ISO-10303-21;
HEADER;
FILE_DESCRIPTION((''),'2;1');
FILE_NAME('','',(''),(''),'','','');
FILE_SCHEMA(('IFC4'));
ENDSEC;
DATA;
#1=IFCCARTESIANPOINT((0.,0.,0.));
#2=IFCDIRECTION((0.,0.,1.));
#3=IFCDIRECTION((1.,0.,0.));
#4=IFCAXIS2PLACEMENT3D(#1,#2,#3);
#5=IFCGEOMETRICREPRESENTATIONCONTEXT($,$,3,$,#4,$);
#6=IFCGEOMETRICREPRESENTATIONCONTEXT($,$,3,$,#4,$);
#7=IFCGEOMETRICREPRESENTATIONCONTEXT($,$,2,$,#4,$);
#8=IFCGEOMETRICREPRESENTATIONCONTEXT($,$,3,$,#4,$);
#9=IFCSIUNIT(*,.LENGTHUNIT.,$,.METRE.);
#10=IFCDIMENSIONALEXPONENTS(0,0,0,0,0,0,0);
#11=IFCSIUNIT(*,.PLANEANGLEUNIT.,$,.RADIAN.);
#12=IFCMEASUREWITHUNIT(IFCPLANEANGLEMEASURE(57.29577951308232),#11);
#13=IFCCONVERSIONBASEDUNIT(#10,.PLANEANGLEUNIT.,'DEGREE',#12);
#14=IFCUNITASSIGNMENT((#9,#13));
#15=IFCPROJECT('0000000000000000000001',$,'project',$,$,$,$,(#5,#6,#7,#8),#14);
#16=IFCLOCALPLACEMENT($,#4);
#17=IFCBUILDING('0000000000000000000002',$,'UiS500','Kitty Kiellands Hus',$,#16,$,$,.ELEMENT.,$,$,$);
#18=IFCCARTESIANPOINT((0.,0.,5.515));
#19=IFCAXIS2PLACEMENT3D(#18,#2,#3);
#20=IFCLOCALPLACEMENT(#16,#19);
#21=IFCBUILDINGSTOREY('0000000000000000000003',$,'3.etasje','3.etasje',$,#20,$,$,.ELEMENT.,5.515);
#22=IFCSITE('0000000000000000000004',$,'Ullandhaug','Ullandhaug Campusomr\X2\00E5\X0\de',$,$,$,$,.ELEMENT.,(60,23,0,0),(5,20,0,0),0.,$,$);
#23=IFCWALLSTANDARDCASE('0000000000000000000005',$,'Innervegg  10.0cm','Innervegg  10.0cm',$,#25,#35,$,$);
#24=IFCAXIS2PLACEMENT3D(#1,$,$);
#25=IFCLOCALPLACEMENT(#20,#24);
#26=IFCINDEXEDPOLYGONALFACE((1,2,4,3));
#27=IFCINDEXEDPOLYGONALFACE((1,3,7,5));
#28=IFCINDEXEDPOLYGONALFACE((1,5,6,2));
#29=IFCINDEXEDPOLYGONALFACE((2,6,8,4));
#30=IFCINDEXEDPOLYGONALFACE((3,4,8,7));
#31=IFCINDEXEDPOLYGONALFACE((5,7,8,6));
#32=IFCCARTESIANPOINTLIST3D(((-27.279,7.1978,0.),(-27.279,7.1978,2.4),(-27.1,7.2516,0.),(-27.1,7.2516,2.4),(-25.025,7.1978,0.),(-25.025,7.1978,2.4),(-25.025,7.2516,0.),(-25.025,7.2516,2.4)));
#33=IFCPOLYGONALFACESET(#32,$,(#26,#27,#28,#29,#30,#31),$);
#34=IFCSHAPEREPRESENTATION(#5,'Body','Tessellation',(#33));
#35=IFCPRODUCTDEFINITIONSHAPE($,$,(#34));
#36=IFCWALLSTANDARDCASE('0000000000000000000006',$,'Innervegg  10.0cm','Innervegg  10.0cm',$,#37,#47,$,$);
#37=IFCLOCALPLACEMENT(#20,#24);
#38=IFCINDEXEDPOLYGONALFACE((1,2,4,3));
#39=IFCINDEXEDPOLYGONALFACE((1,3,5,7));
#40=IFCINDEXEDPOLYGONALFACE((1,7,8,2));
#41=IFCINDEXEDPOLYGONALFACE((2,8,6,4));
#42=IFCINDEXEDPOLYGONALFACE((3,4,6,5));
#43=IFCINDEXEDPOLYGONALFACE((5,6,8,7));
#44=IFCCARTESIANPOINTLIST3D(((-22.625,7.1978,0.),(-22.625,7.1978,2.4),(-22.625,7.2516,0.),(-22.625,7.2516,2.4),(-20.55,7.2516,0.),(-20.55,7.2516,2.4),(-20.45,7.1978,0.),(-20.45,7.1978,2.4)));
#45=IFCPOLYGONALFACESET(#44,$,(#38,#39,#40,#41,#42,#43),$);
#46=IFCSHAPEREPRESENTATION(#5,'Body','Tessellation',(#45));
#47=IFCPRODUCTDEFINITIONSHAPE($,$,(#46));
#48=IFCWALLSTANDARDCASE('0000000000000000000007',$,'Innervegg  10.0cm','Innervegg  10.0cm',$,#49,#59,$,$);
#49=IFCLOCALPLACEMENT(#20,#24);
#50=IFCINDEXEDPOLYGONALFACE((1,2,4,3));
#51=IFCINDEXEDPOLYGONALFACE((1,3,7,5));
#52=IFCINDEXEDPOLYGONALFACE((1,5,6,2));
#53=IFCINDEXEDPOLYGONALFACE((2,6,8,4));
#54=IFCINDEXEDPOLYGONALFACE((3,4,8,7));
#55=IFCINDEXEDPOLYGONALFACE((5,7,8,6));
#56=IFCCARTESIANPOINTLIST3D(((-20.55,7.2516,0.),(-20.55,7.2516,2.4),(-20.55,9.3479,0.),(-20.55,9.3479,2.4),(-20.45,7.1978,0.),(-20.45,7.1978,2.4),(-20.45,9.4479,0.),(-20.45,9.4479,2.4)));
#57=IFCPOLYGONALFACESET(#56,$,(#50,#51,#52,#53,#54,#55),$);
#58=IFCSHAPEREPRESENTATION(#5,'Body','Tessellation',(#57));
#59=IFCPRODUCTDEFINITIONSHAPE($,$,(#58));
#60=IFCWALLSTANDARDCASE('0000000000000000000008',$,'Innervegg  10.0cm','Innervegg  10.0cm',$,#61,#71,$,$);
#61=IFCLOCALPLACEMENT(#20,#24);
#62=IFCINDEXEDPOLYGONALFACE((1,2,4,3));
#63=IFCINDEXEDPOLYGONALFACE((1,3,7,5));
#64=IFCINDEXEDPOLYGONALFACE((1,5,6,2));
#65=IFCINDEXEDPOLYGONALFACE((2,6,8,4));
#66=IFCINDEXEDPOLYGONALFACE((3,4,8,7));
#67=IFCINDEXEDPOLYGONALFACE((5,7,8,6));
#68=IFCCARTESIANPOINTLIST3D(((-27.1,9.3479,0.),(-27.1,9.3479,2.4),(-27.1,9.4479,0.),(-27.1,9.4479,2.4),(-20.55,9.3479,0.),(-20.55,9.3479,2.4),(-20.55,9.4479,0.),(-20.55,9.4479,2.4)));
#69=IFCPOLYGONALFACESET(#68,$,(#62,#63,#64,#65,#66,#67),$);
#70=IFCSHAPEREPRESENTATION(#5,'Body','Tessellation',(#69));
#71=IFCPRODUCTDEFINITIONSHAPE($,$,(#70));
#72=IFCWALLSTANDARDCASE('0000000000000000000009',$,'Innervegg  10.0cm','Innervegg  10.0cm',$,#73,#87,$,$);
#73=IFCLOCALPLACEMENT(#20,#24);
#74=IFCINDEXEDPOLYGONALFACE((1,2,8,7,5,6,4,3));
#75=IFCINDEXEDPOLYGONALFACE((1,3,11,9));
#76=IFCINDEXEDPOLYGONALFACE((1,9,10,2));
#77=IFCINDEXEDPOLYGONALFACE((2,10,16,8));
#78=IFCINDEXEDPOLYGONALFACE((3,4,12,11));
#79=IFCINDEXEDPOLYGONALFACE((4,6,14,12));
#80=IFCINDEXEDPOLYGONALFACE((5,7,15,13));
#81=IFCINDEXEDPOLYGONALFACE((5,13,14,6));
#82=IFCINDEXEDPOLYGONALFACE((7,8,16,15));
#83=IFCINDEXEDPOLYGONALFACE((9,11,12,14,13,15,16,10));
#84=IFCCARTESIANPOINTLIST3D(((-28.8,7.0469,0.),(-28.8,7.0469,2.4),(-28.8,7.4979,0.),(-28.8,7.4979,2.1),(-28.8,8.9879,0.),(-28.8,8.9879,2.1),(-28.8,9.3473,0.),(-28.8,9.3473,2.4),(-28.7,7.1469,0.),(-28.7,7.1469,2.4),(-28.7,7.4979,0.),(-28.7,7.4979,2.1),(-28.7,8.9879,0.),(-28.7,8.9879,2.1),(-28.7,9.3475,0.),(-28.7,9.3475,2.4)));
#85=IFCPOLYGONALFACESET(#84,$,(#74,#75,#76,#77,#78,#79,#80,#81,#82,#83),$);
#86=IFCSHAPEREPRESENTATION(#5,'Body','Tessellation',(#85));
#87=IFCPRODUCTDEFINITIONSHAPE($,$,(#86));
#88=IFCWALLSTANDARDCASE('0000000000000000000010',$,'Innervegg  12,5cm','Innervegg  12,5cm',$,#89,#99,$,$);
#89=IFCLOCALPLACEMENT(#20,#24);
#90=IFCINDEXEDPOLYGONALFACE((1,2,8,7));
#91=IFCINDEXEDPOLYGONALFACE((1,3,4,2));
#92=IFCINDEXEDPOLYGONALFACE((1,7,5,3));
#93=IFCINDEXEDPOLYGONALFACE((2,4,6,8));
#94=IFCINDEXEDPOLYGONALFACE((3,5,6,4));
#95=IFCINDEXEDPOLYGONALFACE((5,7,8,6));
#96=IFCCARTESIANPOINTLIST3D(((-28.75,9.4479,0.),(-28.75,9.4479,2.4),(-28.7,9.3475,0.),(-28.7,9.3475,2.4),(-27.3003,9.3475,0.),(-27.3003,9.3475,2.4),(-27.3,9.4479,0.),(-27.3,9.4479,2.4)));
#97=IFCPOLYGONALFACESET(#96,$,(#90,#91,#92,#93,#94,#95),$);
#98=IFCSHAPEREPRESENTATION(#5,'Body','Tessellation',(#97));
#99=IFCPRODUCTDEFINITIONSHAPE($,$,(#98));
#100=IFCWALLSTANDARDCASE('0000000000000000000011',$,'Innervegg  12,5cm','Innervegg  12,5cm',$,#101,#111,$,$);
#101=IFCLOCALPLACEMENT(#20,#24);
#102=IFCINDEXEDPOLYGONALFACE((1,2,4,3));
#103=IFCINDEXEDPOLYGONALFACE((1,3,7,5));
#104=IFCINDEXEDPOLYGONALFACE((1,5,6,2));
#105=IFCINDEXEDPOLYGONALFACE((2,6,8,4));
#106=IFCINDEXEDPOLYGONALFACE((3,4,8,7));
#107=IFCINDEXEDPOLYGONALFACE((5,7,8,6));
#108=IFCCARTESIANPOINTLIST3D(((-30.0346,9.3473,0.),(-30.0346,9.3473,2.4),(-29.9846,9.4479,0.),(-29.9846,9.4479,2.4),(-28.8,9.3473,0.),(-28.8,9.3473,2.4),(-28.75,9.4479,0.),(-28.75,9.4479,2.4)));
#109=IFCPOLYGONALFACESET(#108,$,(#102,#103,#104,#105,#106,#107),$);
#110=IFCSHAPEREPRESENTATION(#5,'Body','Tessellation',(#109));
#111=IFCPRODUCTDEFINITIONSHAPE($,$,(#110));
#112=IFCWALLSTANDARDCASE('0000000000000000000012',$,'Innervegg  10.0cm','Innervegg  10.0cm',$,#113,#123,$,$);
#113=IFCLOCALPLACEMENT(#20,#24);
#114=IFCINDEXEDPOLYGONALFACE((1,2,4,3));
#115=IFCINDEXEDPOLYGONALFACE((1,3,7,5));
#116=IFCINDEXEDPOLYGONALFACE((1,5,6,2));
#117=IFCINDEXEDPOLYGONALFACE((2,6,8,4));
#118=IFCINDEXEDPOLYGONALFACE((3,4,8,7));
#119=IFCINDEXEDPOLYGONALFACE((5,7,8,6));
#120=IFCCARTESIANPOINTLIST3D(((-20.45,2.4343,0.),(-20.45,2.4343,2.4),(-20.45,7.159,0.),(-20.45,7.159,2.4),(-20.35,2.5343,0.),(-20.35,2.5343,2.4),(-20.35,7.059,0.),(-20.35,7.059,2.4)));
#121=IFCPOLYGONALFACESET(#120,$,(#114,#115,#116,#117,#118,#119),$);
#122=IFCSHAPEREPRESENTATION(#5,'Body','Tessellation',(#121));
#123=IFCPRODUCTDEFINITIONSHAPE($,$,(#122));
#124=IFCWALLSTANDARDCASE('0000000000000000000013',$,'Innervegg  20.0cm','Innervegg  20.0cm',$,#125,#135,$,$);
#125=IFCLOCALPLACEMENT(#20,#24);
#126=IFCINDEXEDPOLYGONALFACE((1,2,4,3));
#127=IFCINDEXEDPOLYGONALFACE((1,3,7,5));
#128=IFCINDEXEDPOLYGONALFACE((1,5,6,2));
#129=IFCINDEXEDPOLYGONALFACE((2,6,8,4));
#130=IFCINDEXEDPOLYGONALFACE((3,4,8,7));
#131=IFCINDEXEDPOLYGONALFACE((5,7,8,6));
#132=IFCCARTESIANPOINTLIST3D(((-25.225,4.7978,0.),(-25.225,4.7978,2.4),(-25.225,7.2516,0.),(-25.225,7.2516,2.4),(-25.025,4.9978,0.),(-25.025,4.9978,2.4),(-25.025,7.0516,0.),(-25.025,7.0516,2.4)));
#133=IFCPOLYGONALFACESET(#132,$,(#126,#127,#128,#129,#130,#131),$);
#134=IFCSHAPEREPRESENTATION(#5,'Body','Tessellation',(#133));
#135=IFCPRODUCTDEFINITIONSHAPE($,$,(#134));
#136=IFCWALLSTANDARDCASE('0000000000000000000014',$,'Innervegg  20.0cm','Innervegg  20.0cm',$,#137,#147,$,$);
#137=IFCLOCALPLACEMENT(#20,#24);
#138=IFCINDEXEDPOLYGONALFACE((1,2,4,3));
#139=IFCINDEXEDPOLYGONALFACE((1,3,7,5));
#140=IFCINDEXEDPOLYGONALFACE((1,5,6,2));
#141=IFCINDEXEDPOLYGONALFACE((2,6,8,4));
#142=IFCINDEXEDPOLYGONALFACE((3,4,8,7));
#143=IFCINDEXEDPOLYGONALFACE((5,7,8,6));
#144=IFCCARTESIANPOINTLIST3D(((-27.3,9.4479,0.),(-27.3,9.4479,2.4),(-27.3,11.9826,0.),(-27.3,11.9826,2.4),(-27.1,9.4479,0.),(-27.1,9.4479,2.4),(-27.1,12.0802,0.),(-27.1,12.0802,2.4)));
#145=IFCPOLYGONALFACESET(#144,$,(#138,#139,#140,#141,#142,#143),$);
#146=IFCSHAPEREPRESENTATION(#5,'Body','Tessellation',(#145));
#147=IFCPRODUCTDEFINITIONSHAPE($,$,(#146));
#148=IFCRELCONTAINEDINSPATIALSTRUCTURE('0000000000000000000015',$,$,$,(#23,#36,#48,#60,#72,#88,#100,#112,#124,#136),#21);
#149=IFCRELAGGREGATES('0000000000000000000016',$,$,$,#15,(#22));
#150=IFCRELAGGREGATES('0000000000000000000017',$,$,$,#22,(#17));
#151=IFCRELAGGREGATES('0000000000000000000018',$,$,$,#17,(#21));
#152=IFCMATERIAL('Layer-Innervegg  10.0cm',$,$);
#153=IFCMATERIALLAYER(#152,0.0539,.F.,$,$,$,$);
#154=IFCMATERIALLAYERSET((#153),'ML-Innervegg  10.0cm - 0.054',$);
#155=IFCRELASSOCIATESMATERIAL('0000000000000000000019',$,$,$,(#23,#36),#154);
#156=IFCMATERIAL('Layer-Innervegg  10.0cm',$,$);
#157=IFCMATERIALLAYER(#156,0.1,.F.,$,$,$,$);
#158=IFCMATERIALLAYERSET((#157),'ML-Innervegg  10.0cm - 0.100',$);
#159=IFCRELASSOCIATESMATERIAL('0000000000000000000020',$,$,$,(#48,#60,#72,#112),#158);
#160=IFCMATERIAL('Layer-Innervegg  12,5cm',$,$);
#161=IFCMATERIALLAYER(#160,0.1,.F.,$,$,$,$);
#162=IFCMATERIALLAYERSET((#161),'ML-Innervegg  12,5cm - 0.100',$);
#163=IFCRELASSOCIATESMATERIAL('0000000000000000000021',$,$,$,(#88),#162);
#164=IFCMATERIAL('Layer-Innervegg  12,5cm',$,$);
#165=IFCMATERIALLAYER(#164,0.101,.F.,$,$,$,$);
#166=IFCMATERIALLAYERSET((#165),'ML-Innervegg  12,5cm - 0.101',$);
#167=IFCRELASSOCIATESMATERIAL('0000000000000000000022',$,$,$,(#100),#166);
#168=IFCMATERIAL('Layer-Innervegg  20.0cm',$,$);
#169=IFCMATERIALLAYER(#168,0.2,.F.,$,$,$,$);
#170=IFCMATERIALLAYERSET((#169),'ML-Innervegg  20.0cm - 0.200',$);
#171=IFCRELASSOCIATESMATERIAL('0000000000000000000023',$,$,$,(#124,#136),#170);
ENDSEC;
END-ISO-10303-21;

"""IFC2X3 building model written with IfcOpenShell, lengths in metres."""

from ifc_helpers import new_model, entity, si_unit, converted_unit, frame, origin_with_axes, place, context, project, spatial, polyline, outline, extrude, material, layer, layer_set, layer_usage, element, save


model = new_model("IFC2X3")

# Units and contexts
context_of_model_1 = context(None, 3, world=origin_with_axes())
context_of_model_2 = context(None, 3, world=origin_with_axes())
context_of_model_3 = context(None, 2, world=origin_with_axes())
context_of_model_4 = context(None, 3, world=origin_with_axes())
ifc_project = project(units=[si_unit("LENGTHUNIT", "METRE"), converted_unit("PLANEANGLEUNIT", "DEGREE", entity("IfcPlaneAngleMeasure", 57.29577951308232), si_unit("PLANEANGLEUNIT", "RADIAN"), dimensions=[0, 0, 0, 0, 0, 0, 0])], contexts=[context_of_model_1, context_of_model_2, context_of_model_3, context_of_model_4])

# Site, building, storey
site = spatial("IfcSite", under=ifc_project, Name="Ullandhaug", Description="Ullandhaug Campusområde", CompositionType="ELEMENT", RefLatitude=(60, 23, 0, 0), RefLongitude=(5, 20, 0, 0), RefElevation=0.0)
building_placement = place(None, origin_with_axes())
building = spatial("IfcBuilding", under=site, at=building_placement, Name="UiS500", Description="Kitty Kiellands Hus", CompositionType="ELEMENT")
storey_placement = place(building_placement, frame((0.0, 0.0, 5.515), z_axis=(0.0, 0.0, 1.0), x_axis=(1.0, 0.0, 0.0)))
storey = spatial("IfcBuildingStorey", under=building, at=storey_placement, Name="3.etasje", Description="3.etasje", CompositionType="ELEMENT", Elevation=5.515)

# Shared definitions
ifc_material_1 = material(Name="Layer-Innervegg  10.0cm")
ifc_layer_1 = layer(ifc_material_1, 0.1, ventilated=False)
ifc_layer_set_1 = layer_set([ifc_layer_1], Name="ML-Innervegg  10.0cm - 0.100")
ifc_layer_usage_1 = layer_usage(ifc_layer_set_1, "AXIS2", "POSITIVE", 0.0)
ifc_material_2 = material(Name="Layer-Innervegg  20.0cm")
ifc_layer_2 = layer(ifc_material_2, 0.2, ventilated=False)
ifc_layer_set_2 = layer_set([ifc_layer_2], Name="ML-Innervegg  20.0cm - 0.200")
ifc_layer_usage_2 = layer_usage(ifc_layer_set_2, "AXIS2", "POSITIVE", 0.0)

# Walls
ifc_material_3 = material(Name="Layer-Innervegg  10.0cm")
ifc_layer_3 = layer(ifc_material_3, 0.0539, ventilated=False)
ifc_layer_set_3 = layer_set([ifc_layer_3], Name="ML-Innervegg  10.0cm - 0.054")
ifc_layer_usage_3 = layer_usage(ifc_layer_set_3, "AXIS2", "POSITIVE", 0.0)
wall_1_placement = place(storey_placement, frame((-27.279, 7.1978, 0.0), z_axis=(0.0, 0.0, 1.0), x_axis=(1.0, 0.0, 0.0)))
element("IfcWallStandardCase", 1, at=wall_1_placement, inside=storey, material=ifc_layer_usage_3, Name="Innervegg  10.0cm", Description="Innervegg  10.0cm", context=context_of_model_1, shape_type="SweptSolid", body=[
    extrude(outline(polyline([(0.0, 0.0), (2.254, 0.0), (2.254, 0.0539), (0.179, 0.0539), (0.0, 0.0)])), origin_with_axes(), (0.0, 0.0, 1.0), 2.4),
])
wall_2_placement = place(storey_placement, frame((-22.625, 7.1978, 0.0), z_axis=(0.0, 0.0, 1.0), x_axis=(1.0, 0.0, 0.0)))
element("IfcWallStandardCase", 2, at=wall_2_placement, inside=storey, material=ifc_layer_usage_3, Name="Innervegg  10.0cm", Description="Innervegg  10.0cm", context=context_of_model_1, shape_type="SweptSolid", body=[
    extrude(outline(polyline([(0.0, 0.0), (2.175, 0.0), (2.075, 0.0539), (0.0, 0.0539), (0.0, 0.0)])), origin_with_axes(), (0.0, 0.0, 1.0), 2.4),
])
wall_3_placement = place(storey_placement, frame((-20.45, 7.1978, 0.0), z_axis=(0.0, 0.0, 1.0), x_axis=(0.0, 1.0, 0.0)))
element("IfcWallStandardCase", 3, at=wall_3_placement, inside=storey, material=ifc_layer_usage_1, Name="Innervegg  10.0cm", Description="Innervegg  10.0cm", context=context_of_model_1, shape_type="SweptSolid", body=[
    extrude(outline(polyline([(0.0, 0.0), (2.2502, 0.0), (2.1502, 0.1), (0.0539, 0.1), (0.0, 0.0)])), frame((0.0, 0.0, 0.0), z_axis=(0.0, 0.0, 1.0), x_axis=(1.0, 0.0, 0.0)), (0.0, 0.0, 1.0), 2.4),
])
wall_4_placement = place(storey_placement, frame((-20.55, 9.4479, 0.0), z_axis=(0.0, 0.0, 1.0), x_axis=(-1.0, 0.000003, 0.0)))
element("IfcWallStandardCase", 4, at=wall_4_placement, inside=storey, material=ifc_layer_usage_1, Name="Innervegg  10.0cm", Description="Innervegg  10.0cm", context=context_of_model_1, shape_type="SweptSolid", body=[
    extrude(outline(polyline([(0.0, 0.0), (6.55, 0.0), (6.55, 0.1), (0.0, 0.1), (0.0, 0.0)])), frame((0.0, 0.0, 0.0), z_axis=(0.0, 0.0, 1.0), x_axis=(1.0, 0.0, 0.0)), (0.0, 0.0, 1.0), 2.4),
])

# Wall, opening
wall_5_placement = place(storey_placement, frame((-28.8, 9.3473, 0.0), z_axis=(0.0, 0.0, 1.0), x_axis=(0.0, -1.0, 0.0)))
wall_5 = element("IfcWallStandardCase", 5, at=wall_5_placement, inside=storey, material=ifc_layer_usage_1, Name="Innervegg  10.0cm", Description="Innervegg  10.0cm", context=context_of_model_1, shape_type="SweptSolid", body=[
    extrude(outline(polyline([(0.0, 0.0), (2.3004, 0.0), (2.2004, 0.1), (-0.0002, 0.1), (0.0, 0.0)])), frame((0.0, 0.0, 0.0), z_axis=(0.0, 0.0, 1.0), x_axis=(1.0, 0.0, 0.0)), (0.0, 0.0, 1.0), 2.4),
])
opening_1_placement = place(wall_5_placement, frame((0.3594, 0.1, 0.0), z_axis=(0.0, 0.0, 1.0), x_axis=(1.0, 0.0, 0.0)))
element("IfcOpeningElement", 6, at=opening_1_placement, cuts=wall_5, context=context_of_model_1, shape_type="SweptSolid", body=[
    extrude(outline(polyline([(0.0, 0.0), (2.1, 0.0), (2.1, 1.49), (0.0, 1.49), (0.0, 0.0)])), frame((0.0, 0.0, 0.0), z_axis=(0.0, 1.0, 0.0), x_axis=(0.0, 0.0, 1.0)), (0.0, 0.0, -1.0), 0.1),
])

# Walls
ifc_material_4 = material(Name="Layer-Innervegg  12,5cm")
ifc_layer_4 = layer(ifc_material_4, 0.1, ventilated=False)
ifc_layer_set_4 = layer_set([ifc_layer_4], Name="ML-Innervegg  12,5cm - 0.100")
ifc_layer_usage_4 = layer_usage(ifc_layer_set_4, "AXIS2", "POSITIVE", 0.0)
wall_6_placement = place(storey_placement, frame((-27.3, 9.4479, 0.0), z_axis=(0.0, 0.0, 1.0), x_axis=(-1.0, 0.0, 0.0)))
element("IfcWallStandardCase", 7, at=wall_6_placement, inside=storey, material=ifc_layer_usage_4, Name="Innervegg  12,5cm", Description="Innervegg  12,5cm", context=context_of_model_1, shape_type="SweptSolid", body=[
    extrude(outline(polyline([(0.0, 0.0), (1.45, 0.0), (1.4, 0.1004), (0.0002, 0.1004), (0.0, 0.0)])), frame((0.0, 0.0, 0.0), z_axis=(0.0, 0.0, 1.0), x_axis=(1.0, 0.0, 0.0)), (0.0, 0.0, 1.0), 2.4),
])
ifc_material_5 = material(Name="Layer-Innervegg  12,5cm")
ifc_layer_5 = layer(ifc_material_5, 0.101, ventilated=False)
ifc_layer_set_5 = layer_set([ifc_layer_5], Name="ML-Innervegg  12,5cm - 0.101")
ifc_layer_usage_5 = layer_usage(ifc_layer_set_5, "AXIS2", "POSITIVE", 0.0)
wall_7_placement = place(storey_placement, frame((-28.75, 9.4479, 0.0), z_axis=(0.0, 0.0, 1.0), x_axis=(-1.0, 0.0, 0.0)))
element("IfcWallStandardCase", 8, at=wall_7_placement, inside=storey, material=ifc_layer_usage_5, Name="Innervegg  12,5cm", Description="Innervegg  12,5cm", context=context_of_model_1, shape_type="SweptSolid", body=[
    extrude(outline(polyline([(0.0, 0.0), (1.2346, 0.0), (1.2846, 0.1007), (0.05, 0.1007), (0.0, 0.0)])), frame((0.0, 0.0, 0.0), z_axis=(0.0, 0.0, 1.0), x_axis=(1.0, 0.0, 0.0)), (0.0, 0.0, 1.0), 2.4),
])
wall_8_placement = place(storey_placement, frame((-20.45, 7.159, 0.0), z_axis=(0.0, 0.0, 1.0), x_axis=(0.0, -1.0, 0.0)))
element("IfcWallStandardCase", 9, at=wall_8_placement, inside=storey, material=ifc_layer_usage_1, Name="Innervegg  10.0cm", Description="Innervegg  10.0cm", context=context_of_model_1, shape_type="SweptSolid", body=[
    extrude(outline(polyline([(0.0, 0.0), (4.7247, 0.0), (4.6247, 0.1), (0.1, 0.1), (0.0, 0.0)])), frame((0.0, 0.0, 0.0), z_axis=(0.0, 0.0, 1.0), x_axis=(1.0, 0.0, 0.0)), (0.0, 0.0, 1.0), 2.4),
])
wall_9_placement = place(storey_placement, frame((-25.225, 7.2516, 0.0), z_axis=(0.0, 0.0, 1.0), x_axis=(0.0, -1.0, 0.0)))
element("IfcWallStandardCase", 10, at=wall_9_placement, inside=storey, material=ifc_layer_usage_2, Name="Innervegg  20.0cm", Description="Innervegg  20.0cm", context=context_of_model_1, shape_type="SweptSolid", body=[
    extrude(outline(polyline([(0.0, 0.0), (2.4539, 0.0), (2.2539, 0.2), (0.2, 0.2), (0.0, 0.0)])), frame((0.0, 0.0, 0.0), z_axis=(0.0, 0.0, 1.0), x_axis=(1.0, 0.0, 0.0)), (0.0, 0.0, 1.0), 2.4),
])
wall_10_placement = place(storey_placement, frame((-27.1, 9.4479, 0.0), z_axis=(0.0, 0.0, 1.0), x_axis=(0.0, 1.0, 0.0)))
element("IfcWallStandardCase", 11, at=wall_10_placement, inside=storey, material=ifc_layer_usage_2, Name="Innervegg  20.0cm", Description="Innervegg  20.0cm", context=context_of_model_1, shape_type="SweptSolid", body=[
    extrude(outline(polyline([(0.0, 0.0), (2.6323, 0.0), (2.5347, 0.2), (0.0, 0.2), (0.0, 0.0)])), frame((0.0, 0.0, 0.0), z_axis=(0.0, 0.0, 1.0), x_axis=(1.0, 0.0, 0.0)), (0.0, 0.0, 1.0), 2.4),
])

save(model, "model.ifc")
